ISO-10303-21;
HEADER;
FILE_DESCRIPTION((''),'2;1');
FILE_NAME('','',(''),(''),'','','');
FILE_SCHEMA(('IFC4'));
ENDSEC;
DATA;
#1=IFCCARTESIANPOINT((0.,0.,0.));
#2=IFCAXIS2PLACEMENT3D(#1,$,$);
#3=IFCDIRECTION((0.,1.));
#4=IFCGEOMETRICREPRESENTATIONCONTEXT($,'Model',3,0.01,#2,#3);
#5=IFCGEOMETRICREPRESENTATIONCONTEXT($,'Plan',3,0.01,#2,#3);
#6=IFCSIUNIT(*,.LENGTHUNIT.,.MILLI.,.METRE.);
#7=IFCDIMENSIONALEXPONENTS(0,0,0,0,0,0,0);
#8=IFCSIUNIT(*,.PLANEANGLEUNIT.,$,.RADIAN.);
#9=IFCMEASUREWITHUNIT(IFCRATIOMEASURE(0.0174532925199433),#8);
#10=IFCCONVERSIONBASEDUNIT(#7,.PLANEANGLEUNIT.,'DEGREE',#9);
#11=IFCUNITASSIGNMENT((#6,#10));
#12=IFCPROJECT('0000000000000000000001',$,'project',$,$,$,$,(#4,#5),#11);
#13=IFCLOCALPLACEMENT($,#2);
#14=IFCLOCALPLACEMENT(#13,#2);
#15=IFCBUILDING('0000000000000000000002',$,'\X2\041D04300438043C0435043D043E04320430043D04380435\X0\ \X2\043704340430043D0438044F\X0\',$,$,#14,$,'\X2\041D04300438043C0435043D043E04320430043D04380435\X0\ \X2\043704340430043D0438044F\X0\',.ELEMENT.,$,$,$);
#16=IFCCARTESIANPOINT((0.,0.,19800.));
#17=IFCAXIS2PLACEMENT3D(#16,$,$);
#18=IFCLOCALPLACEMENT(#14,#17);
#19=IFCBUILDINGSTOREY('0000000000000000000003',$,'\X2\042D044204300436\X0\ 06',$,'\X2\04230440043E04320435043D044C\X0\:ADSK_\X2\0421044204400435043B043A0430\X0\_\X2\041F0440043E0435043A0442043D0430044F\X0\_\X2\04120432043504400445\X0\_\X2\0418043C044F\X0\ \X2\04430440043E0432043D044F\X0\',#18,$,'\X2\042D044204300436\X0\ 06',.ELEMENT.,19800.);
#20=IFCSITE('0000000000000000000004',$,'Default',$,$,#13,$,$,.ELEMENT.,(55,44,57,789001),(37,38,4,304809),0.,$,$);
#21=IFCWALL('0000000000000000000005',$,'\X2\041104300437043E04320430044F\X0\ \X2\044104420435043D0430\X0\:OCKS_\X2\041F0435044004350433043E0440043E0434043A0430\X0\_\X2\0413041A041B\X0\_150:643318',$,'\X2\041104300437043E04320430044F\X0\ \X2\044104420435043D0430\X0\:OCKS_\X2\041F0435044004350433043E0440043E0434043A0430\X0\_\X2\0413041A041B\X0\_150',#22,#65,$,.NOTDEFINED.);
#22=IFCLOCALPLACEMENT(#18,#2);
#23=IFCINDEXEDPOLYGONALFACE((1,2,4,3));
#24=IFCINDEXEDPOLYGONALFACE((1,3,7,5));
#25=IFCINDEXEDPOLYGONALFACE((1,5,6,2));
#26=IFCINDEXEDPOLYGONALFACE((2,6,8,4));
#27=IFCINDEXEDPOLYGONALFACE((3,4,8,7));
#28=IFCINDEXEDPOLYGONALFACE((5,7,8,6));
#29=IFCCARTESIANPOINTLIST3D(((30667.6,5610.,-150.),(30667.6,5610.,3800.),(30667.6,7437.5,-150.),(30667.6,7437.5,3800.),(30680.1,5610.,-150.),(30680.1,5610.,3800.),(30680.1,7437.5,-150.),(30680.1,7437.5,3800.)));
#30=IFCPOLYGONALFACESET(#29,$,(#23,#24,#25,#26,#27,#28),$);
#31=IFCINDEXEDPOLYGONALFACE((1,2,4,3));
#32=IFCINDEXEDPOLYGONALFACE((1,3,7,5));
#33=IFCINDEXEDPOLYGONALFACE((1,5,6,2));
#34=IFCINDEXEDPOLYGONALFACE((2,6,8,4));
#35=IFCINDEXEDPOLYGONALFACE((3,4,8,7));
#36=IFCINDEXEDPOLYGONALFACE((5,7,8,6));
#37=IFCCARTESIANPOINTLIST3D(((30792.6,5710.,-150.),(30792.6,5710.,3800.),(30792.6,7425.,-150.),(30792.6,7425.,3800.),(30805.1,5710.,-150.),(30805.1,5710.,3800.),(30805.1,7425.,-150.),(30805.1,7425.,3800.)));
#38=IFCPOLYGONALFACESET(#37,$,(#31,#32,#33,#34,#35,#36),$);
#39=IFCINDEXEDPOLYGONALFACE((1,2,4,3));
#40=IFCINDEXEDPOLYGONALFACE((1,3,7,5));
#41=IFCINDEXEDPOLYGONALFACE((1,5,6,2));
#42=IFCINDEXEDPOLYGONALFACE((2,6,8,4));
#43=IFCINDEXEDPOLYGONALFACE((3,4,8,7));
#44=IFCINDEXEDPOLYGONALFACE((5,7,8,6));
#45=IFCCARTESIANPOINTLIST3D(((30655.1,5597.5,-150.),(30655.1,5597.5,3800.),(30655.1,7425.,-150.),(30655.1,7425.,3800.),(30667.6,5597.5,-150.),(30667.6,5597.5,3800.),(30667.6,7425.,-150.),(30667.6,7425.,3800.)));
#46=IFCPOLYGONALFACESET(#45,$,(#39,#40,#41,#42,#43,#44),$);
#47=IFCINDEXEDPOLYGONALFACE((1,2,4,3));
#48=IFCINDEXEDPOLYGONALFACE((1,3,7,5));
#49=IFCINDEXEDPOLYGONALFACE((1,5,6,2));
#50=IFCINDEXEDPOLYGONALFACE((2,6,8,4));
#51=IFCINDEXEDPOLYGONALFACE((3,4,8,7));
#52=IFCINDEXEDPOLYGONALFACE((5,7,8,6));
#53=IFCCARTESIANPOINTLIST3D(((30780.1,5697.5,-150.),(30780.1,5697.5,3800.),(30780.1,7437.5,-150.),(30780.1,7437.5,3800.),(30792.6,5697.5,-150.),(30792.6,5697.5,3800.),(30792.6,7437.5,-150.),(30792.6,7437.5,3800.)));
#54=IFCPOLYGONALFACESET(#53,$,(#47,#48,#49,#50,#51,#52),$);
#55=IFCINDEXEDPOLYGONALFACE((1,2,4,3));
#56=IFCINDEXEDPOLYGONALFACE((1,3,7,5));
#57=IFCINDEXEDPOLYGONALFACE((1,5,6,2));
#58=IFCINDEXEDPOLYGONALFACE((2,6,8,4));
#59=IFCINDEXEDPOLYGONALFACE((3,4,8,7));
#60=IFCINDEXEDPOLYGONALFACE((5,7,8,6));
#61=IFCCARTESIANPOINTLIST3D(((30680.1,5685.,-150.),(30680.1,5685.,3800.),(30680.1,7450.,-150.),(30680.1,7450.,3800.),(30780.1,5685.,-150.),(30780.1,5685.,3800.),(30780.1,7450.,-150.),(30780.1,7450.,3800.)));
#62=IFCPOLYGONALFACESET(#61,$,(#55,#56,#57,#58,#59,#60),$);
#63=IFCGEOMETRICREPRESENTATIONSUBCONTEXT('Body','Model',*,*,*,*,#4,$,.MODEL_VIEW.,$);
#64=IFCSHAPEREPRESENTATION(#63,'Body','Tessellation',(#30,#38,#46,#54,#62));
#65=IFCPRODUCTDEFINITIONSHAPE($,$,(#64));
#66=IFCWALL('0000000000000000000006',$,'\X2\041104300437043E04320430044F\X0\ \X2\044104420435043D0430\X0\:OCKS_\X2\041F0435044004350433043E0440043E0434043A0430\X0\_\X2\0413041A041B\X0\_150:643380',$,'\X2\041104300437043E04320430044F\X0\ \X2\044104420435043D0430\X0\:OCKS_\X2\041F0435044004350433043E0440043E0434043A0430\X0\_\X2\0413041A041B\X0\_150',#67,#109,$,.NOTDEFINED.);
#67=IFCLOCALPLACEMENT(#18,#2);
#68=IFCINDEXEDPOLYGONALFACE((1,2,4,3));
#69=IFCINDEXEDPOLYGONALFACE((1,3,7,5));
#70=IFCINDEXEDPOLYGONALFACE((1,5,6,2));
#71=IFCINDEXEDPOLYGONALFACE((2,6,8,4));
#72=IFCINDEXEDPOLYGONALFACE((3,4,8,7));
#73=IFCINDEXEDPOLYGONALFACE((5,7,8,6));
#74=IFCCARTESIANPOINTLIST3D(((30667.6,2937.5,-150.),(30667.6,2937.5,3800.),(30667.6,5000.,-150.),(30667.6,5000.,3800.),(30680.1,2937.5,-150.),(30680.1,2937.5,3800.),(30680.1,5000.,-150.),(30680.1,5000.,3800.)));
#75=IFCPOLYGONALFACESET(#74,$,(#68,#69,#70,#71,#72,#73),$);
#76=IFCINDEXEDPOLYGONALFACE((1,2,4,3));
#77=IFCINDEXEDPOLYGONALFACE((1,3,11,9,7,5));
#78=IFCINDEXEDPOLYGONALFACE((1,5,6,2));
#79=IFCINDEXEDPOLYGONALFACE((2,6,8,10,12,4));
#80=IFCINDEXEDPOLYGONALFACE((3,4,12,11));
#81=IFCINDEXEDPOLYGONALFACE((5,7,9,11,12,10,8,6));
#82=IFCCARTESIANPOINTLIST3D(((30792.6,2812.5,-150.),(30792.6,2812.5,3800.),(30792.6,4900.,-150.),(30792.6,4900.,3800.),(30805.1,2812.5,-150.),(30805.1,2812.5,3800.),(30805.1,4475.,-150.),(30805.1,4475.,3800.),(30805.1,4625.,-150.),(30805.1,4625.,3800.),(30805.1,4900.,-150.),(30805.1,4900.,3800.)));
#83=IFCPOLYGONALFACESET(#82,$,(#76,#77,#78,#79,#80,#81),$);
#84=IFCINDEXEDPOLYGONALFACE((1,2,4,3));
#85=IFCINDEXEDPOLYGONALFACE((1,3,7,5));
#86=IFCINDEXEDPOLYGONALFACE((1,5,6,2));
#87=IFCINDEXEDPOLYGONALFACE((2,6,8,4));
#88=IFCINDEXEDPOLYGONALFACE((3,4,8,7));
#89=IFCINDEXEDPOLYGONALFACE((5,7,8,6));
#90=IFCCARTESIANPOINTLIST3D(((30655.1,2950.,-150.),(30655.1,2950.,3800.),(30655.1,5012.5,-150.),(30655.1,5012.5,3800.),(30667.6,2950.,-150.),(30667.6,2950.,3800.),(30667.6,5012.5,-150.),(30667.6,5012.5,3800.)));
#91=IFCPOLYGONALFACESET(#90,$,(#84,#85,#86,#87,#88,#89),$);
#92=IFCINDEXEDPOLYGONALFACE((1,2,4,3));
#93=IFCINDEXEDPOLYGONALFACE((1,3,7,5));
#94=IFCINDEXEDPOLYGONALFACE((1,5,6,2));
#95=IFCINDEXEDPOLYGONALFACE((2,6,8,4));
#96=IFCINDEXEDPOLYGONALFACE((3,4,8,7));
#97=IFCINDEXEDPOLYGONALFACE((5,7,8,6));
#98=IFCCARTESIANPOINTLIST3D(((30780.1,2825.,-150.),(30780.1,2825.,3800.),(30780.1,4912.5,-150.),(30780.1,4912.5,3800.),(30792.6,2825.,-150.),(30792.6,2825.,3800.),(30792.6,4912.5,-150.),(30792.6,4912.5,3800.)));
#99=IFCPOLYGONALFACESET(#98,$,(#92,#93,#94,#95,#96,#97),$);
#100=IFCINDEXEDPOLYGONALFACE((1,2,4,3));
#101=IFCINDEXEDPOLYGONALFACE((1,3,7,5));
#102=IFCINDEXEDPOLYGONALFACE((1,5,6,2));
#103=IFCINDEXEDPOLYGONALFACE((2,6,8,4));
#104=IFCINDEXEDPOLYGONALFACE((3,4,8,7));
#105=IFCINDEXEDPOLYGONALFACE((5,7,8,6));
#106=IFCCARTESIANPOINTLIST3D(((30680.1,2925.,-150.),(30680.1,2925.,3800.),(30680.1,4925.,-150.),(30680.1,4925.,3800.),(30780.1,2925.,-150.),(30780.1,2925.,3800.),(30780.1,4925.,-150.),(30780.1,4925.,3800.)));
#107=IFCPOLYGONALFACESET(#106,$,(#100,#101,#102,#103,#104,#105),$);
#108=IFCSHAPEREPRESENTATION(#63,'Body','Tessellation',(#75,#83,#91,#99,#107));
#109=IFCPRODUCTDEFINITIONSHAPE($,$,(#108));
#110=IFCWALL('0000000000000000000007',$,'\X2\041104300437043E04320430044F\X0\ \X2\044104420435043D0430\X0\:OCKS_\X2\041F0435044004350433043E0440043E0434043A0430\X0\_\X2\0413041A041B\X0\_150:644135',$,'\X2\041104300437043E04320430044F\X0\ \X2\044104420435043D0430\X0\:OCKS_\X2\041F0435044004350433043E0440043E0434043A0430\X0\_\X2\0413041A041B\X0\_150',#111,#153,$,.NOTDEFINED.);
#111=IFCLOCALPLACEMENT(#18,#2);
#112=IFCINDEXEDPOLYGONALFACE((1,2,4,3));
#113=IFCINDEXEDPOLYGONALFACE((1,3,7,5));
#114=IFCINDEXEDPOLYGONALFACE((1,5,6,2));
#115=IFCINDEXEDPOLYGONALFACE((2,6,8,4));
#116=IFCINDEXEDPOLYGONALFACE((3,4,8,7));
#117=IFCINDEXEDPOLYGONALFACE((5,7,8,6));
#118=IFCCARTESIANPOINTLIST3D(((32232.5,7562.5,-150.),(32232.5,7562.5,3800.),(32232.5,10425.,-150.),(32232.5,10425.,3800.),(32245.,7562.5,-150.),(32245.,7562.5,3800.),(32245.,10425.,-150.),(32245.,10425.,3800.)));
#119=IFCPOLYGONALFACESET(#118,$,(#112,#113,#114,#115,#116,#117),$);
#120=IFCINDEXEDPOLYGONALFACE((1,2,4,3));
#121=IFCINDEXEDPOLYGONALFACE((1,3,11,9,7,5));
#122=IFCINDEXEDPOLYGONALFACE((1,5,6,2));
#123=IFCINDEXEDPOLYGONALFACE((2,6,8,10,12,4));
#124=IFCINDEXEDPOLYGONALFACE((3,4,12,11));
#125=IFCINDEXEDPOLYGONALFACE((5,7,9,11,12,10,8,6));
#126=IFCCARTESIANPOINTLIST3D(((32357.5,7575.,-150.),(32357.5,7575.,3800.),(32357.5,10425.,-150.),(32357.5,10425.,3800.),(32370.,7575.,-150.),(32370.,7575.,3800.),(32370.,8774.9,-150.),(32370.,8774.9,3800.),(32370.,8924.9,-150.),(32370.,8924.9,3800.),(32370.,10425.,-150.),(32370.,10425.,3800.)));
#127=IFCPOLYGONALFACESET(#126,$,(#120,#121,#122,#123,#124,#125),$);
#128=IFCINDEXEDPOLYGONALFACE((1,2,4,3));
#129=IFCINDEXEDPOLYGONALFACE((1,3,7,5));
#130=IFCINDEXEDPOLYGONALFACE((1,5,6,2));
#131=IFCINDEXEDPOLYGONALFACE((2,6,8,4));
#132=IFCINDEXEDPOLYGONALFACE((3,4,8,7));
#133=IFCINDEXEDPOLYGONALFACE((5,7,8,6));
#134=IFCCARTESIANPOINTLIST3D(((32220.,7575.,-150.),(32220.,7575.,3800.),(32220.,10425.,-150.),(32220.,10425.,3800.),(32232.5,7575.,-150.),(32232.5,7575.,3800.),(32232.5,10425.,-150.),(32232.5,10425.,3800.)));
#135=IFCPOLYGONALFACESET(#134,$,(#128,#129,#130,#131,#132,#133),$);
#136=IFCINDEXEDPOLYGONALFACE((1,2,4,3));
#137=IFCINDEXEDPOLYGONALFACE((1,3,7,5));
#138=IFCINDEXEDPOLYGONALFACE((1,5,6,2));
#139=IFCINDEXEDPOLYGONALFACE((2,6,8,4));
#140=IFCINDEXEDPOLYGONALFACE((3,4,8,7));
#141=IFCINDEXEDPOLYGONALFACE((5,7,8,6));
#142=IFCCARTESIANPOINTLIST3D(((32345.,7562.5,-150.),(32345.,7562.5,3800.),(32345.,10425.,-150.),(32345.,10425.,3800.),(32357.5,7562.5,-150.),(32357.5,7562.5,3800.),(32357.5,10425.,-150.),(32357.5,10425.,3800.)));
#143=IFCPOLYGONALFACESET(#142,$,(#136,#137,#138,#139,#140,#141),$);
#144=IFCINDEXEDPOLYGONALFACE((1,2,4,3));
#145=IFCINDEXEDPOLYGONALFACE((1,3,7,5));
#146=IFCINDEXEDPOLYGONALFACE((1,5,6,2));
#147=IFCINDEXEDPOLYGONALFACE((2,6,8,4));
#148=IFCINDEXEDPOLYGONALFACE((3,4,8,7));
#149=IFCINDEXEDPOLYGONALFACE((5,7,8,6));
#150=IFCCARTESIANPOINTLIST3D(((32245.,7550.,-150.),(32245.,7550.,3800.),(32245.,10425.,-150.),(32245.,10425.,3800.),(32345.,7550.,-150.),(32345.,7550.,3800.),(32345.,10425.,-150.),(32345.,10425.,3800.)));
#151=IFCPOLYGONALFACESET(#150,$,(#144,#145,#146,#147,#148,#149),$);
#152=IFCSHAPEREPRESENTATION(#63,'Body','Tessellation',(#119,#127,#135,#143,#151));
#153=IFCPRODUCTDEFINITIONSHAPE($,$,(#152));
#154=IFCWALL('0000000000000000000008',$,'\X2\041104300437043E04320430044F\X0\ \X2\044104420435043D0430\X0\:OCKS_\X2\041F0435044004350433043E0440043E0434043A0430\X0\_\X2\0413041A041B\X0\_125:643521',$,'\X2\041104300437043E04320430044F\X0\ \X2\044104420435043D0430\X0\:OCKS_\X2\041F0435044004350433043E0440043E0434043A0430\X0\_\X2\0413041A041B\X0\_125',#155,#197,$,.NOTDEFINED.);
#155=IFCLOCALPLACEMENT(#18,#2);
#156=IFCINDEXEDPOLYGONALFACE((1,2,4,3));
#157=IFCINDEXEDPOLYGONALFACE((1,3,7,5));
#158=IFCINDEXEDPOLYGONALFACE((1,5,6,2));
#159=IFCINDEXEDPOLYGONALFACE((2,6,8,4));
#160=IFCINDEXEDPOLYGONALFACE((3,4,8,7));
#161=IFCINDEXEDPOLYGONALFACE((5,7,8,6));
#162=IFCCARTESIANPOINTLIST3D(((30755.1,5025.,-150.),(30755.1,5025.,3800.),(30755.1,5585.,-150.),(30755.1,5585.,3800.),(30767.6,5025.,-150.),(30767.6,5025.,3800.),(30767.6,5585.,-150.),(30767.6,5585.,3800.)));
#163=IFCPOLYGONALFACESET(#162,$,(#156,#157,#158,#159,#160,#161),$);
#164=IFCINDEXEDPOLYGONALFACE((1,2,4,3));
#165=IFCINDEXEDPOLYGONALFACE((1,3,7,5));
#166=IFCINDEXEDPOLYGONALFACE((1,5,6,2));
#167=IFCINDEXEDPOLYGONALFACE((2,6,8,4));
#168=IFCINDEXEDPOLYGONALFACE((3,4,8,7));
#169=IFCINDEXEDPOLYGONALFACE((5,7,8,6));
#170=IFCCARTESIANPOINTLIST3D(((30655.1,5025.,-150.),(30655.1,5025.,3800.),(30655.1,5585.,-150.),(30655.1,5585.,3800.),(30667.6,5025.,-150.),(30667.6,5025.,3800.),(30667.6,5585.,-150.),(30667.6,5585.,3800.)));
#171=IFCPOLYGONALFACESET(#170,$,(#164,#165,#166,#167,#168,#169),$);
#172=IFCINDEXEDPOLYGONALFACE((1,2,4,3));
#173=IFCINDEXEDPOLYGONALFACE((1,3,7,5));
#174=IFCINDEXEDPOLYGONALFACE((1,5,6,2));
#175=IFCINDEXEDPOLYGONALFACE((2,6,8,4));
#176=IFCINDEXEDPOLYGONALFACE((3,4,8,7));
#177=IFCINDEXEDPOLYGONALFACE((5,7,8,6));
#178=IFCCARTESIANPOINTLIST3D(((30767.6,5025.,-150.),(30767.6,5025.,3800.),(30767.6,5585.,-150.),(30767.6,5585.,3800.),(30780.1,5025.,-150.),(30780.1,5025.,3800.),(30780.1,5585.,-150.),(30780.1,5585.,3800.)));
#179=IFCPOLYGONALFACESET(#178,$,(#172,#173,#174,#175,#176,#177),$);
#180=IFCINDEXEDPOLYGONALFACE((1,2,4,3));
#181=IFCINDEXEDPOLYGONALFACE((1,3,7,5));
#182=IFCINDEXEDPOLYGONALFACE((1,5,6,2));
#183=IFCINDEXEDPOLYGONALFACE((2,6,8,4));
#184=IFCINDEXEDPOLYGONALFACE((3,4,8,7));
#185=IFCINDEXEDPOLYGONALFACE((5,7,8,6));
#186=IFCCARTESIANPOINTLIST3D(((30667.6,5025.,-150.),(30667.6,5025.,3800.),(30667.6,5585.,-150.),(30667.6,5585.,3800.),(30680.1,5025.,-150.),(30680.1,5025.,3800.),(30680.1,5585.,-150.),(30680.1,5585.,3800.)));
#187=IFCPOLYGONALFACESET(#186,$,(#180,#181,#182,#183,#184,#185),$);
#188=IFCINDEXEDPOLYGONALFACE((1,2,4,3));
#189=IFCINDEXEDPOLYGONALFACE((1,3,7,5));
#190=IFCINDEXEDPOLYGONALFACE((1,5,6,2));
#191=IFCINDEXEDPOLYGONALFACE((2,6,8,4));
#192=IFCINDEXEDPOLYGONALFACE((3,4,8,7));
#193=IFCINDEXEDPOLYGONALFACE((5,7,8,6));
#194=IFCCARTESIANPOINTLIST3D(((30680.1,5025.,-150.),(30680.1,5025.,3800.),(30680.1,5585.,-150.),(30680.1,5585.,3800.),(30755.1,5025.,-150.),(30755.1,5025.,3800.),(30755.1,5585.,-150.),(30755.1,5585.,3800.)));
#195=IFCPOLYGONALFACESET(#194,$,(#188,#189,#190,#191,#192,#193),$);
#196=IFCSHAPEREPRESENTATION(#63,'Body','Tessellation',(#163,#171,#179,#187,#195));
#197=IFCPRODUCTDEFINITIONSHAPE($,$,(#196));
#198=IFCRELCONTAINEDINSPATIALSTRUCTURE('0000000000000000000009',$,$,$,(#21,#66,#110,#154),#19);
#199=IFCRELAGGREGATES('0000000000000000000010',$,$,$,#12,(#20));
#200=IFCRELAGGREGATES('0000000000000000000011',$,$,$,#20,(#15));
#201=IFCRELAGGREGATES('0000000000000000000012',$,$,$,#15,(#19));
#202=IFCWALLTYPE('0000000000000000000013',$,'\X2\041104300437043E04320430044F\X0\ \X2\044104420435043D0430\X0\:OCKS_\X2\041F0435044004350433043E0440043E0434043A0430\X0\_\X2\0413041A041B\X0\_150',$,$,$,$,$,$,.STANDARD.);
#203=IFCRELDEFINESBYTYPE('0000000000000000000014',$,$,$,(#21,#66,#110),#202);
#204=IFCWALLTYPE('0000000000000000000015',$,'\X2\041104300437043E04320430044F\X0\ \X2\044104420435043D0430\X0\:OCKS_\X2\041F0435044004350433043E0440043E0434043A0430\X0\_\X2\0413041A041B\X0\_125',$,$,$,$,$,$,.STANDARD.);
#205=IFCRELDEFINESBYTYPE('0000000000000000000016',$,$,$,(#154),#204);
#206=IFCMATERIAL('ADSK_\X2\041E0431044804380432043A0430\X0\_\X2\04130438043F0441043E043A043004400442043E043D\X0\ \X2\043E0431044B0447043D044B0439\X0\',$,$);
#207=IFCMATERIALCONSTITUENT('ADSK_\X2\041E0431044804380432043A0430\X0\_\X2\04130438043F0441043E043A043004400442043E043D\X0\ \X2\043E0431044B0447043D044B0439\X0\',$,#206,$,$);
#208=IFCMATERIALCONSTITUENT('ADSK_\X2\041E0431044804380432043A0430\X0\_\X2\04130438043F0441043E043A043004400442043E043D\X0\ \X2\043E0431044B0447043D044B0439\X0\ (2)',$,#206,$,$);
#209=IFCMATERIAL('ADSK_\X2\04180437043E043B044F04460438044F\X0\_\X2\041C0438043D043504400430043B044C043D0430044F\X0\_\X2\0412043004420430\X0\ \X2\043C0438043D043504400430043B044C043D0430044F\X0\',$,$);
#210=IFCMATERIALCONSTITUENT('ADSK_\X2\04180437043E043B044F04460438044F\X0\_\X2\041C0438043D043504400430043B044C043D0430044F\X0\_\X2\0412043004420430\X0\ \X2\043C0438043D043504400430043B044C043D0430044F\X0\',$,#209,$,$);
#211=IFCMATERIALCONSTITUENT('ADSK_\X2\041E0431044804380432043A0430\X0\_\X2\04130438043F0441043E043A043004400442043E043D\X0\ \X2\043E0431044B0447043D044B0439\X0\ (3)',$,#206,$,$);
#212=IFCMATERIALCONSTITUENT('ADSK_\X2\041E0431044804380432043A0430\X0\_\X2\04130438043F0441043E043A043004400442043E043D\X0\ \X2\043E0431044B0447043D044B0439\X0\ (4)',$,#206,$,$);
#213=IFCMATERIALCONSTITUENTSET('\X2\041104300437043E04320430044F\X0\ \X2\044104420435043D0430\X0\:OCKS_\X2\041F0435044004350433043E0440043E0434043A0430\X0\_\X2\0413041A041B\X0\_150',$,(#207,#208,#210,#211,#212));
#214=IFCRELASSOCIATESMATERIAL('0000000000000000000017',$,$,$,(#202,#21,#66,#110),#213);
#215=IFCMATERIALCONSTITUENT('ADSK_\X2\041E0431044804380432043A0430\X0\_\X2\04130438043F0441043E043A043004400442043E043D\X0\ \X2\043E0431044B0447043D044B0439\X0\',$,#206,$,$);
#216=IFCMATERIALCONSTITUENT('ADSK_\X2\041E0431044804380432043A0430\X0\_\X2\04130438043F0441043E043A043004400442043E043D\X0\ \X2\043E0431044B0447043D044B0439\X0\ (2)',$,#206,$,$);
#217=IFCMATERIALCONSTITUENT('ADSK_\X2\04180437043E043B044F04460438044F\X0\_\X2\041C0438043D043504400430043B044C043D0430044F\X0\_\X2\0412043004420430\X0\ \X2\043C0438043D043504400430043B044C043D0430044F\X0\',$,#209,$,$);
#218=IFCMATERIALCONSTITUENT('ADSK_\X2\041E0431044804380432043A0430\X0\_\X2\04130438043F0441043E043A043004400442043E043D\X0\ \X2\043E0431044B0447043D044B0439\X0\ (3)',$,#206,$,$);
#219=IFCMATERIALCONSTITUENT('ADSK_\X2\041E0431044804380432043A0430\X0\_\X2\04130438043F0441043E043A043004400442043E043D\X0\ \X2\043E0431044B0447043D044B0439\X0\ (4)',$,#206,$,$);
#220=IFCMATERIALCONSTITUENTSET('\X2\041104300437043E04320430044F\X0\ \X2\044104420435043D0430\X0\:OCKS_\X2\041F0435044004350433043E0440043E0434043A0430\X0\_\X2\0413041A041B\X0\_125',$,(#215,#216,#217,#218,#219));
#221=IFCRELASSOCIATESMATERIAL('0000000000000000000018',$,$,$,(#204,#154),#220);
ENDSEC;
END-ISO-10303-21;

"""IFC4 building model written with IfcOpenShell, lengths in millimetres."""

from ifc_helpers import new_model, entity, si_unit, converted_unit, direction, frame, origin, place, context, subcontext, project, spatial, indexed_curve, outline, extrude, material, constituent, constituent_set, type_object, element, save


model = new_model("IFC4")

# Units and contexts
model_context = context("Model", 3, precision=0.01, world=origin(), true_north=direction((0.0, 1.0)))
plan_context = context("Plan", 3, precision=0.01, world=origin(), true_north=direction((0.0, 1.0)))
body_context = subcontext(model_context, "Body", "Model", "MODEL_VIEW")
ifc_project = project(units=[si_unit("LENGTHUNIT", "METRE", prefix="MILLI"), converted_unit("PLANEANGLEUNIT", "DEGREE", entity("IfcRatioMeasure", 0.0174532925199433), si_unit("PLANEANGLEUNIT", "RADIAN"), dimensions=[0, 0, 0, 0, 0, 0, 0])], contexts=[model_context, plan_context])

# Site, building, storey
site_placement = place(None, frame((0.0, 0.0, 0.0)))
site = spatial("IfcSite", under=ifc_project, at=site_placement, Name="Default", CompositionType="ELEMENT", RefLatitude=(55, 44, 57, 789001), RefLongitude=(37, 38, 4, 304809), RefElevation=0.0)
building_placement = place(site_placement, origin())
building = spatial("IfcBuilding", under=site, at=building_placement, Name="Наименование здания", LongName="Наименование здания", CompositionType="ELEMENT")
storey_placement = place(building_placement, frame((0.0, 0.0, 19800.0)))
storey = spatial("IfcBuildingStorey", under=building, at=storey_placement, Name="Этаж 06", ObjectType="Уровень:ADSK_Стрелка_Проектная_Вверх_Имя уровня", LongName="Этаж 06", CompositionType="ELEMENT", Elevation=19800.0)

# Shared definitions
ifc_material_1 = material(Name="ADSK_Обшивка_Гипсокартон обычный")
ifc_constituent_1 = constituent(ifc_material_1, Name="ADSK_Обшивка_Гипсокартон обычный")
ifc_constituent_2 = constituent(ifc_material_1, Name="ADSK_Обшивка_Гипсокартон обычный (2)")
ifc_material_2 = material(Name="ADSK_Изоляция_Минеральная_Вата минеральная")
ifc_constituent_3 = constituent(ifc_material_2, Name="ADSK_Изоляция_Минеральная_Вата минеральная")
ifc_constituent_4 = constituent(ifc_material_1, Name="ADSK_Обшивка_Гипсокартон обычный (3)")
ifc_constituent_5 = constituent(ifc_material_1, Name="ADSK_Обшивка_Гипсокартон обычный (4)")
ifc_constituent_set_1 = constituent_set(constituents=[ifc_constituent_1, ifc_constituent_2, ifc_constituent_3, ifc_constituent_4, ifc_constituent_5], Name="Базовая стена:OCKS_Перегородка_ГКЛ_150")
wall_type_1 = type_object("IfcWallType", Name="Базовая стена:OCKS_Перегородка_ГКЛ_150", PredefinedType="STANDARD", material=ifc_constituent_set_1)

# Walls
wall_1_placement = place(storey_placement, frame((30730.1, 7425.0, -150.0), z_axis=(0.0, 0.0, 1.0), x_axis=(0.0, -1.0, 0.0)))
element("IfcWall", 1, at=wall_1_placement, inside=storey, type_object=wall_type_1, material=ifc_constituent_set_1, Name="Базовая стена:OCKS_Перегородка_ГКЛ_150:643318", ObjectType="Базовая стена:OCKS_Перегородка_ГКЛ_150", PredefinedType="NOTDEFINED", context=body_context, shape_type="SweptSolid", body=[
    extrude(outline(indexed_curve([(-913.8, -6.2), (913.8, -6.2), (913.8, 6.3), (-913.8, 6.3), (-913.8, -6.2)], self_intersect=False)), frame((901.3, -56.3, 0.0)), (0.0, 0.0, 1.0), 3950.0),
    extrude(outline(indexed_curve([(-6.3, -857.5), (6.2, -857.5), (6.3, 857.5), (-6.2, 857.5), (-6.3, -857.5)], self_intersect=False)), frame((857.5, 68.7, 0.0), z_axis=(0.0, 0.0, 1.0), x_axis=(0.0, -1.0, 0.0)), (0.0, 0.0, 1.0), 3950.0),
    extrude(outline(indexed_curve([(-6.3, -913.8), (6.2, -913.8), (6.3, 913.8), (-6.2, 913.8), (-6.3, -913.8)], self_intersect=False)), frame((913.8, -68.8, 0.0), z_axis=(0.0, 0.0, 1.0), x_axis=(0.0, 1.0, 0.0)), (0.0, 0.0, 1.0), 3950.0),
    extrude(outline(indexed_curve([(-870.0, -6.2), (870.0, -6.2), (870.0, 6.3), (-870.0, 6.3), (-870.0, -6.2)], self_intersect=False)), frame((857.5, 56.2, 0.0)), (0.0, 0.0, 1.0), 3950.0),
    extrude(outline(indexed_curve([(-882.5, -50.0), (882.5, -50.0), (882.5, 50.0), (-882.5, 50.0), (-882.5, -50.0)], self_intersect=False)), frame((857.5, 0.0, 0.0)), (0.0, 0.0, 1.0), 3950.0),
])
wall_2_placement = place(storey_placement, frame((30730.1, 4900.0, -150.0), z_axis=(0.0, 0.0, 1.0), x_axis=(0.0, -1.0, 0.0)))
element("IfcWall", 2, at=wall_2_placement, inside=storey, type_object=wall_type_1, material=ifc_constituent_set_1, Name="Базовая стена:OCKS_Перегородка_ГКЛ_150:643380", ObjectType="Базовая стена:OCKS_Перегородка_ГКЛ_150", PredefinedType="NOTDEFINED", context=body_context, shape_type="SweptSolid", body=[
    extrude(outline(indexed_curve([(-1031.3, -6.3), (1031.3, -6.3), (1031.3, 6.2), (-1031.3, 6.2), (-1031.3, -6.3)], self_intersect=False)), frame((931.3, -56.2, 0.0)), (0.0, 0.0, 1.0), 3950.0),
    extrude(outline(indexed_curve([(387.5, -4.2), (537.5, -4.2), (812.5, -4.2), (812.5, 8.3), (-1275.0, 8.3), (-1275.0, -4.2), (387.5, -4.2)], self_intersect=False)), frame((812.5, 70.8, 0.0), z_axis=(0.0, 0.0, 1.0), x_axis=(-1.0, 0.0, 0.0)), (0.0, 0.0, 1.0), 3950.0),
    extrude(outline(indexed_curve([(-6.3, -1031.3), (6.2, -1031.3), (6.3, 1031.3), (-6.2, 1031.3), (-6.3, -1031.3)], self_intersect=False)), frame((918.8, -68.8, 0.0), z_axis=(0.0, 0.0, 1.0), x_axis=(0.0, 1.0, 0.0)), (0.0, 0.0, 1.0), 3950.0),
    extrude(outline(indexed_curve([(-1043.8, -6.3), (1043.8, -6.3), (1043.8, 6.2), (-1043.8, 6.2), (-1043.8, -6.3)], self_intersect=False)), frame((1031.3, 56.3, 0.0)), (0.0, 0.0, 1.0), 3950.0),
    extrude(outline(indexed_curve([(-1000.0, -50.0), (1000.0, -50.0), (1000.0, 50.0), (-1000.0, 50.0), (-1000.0, -50.0)], self_intersect=False)), frame((975.0, 0.0, 0.0)), (0.0, 0.0, 1.0), 3950.0),
])

# Walls
wall_3_placement = place(storey_placement, frame((32295.0, 10425.0, -150.0), z_axis=(0.0, 0.0, 1.0), x_axis=(0.0, -1.0, 0.0)))
element("IfcWall", 3, at=wall_3_placement, inside=storey, type_object=wall_type_1, material=ifc_constituent_set_1, Name="Базовая стена:OCKS_Перегородка_ГКЛ_150:644135", ObjectType="Базовая стена:OCKS_Перегородка_ГКЛ_150", PredefinedType="NOTDEFINED", context=body_context, shape_type="SweptSolid", body=[
    extrude(outline(indexed_curve([(-1431.2, -6.2), (1431.2, -6.2), (1431.2, 6.3), (-1431.2, 6.3), (-1431.2, -6.2)], self_intersect=False)), frame((1431.2, -56.3, 0.0)), (0.0, 0.0, 1.0), 3950.0),
    extrude(outline(indexed_curve([(-175.0, -4.2), (-25.0, -4.2), (1475.0, -4.2), (1475.0, 8.3), (-1375.0, 8.3), (-1375.0, -4.2), (-175.0, -4.2)], self_intersect=False)), frame((1475.0, 70.8, 0.0), z_axis=(0.0, 0.0, 1.0), x_axis=(-1.0, 0.0, 0.0)), (0.0, 0.0, 1.0), 3950.0),
    extrude(outline(indexed_curve([(-6.3, -1425.0), (6.2, -1425.0), (6.3, 1425.0), (-6.2, 1425.0), (-6.3, -1425.0)], self_intersect=False)), frame((1425.0, -68.7, 0.0), z_axis=(0.0, 0.0, 1.0), x_axis=(0.0, 1.0, 0.0)), (0.0, 0.0, 1.0), 3950.0),
    extrude(outline(indexed_curve([(-1431.2, -6.2), (1431.2, -6.2), (1431.2, 6.3), (-1431.2, 6.3), (-1431.2, -6.2)], self_intersect=False)), frame((1431.2, 56.2, 0.0)), (0.0, 0.0, 1.0), 3950.0),
    extrude(outline(indexed_curve([(-1437.5, -50.0), (1437.5, -50.0), (1437.5, 50.0), (-1437.5, 50.0), (-1437.5, -50.0)], self_intersect=False)), frame((1437.5, 0.0, 0.0)), (0.0, 0.0, 1.0), 3950.0),
])
ifc_constituent_6 = constituent(ifc_material_1, Name="ADSK_Обшивка_Гипсокартон обычный")
ifc_constituent_7 = constituent(ifc_material_1, Name="ADSK_Обшивка_Гипсокартон обычный (2)")
ifc_constituent_8 = constituent(ifc_material_2, Name="ADSK_Изоляция_Минеральная_Вата минеральная")
ifc_constituent_9 = constituent(ifc_material_1, Name="ADSK_Обшивка_Гипсокартон обычный (3)")
ifc_constituent_10 = constituent(ifc_material_1, Name="ADSK_Обшивка_Гипсокартон обычный (4)")
ifc_constituent_set_2 = constituent_set(constituents=[ifc_constituent_6, ifc_constituent_7, ifc_constituent_8, ifc_constituent_9, ifc_constituent_10], Name="Базовая стена:OCKS_Перегородка_ГКЛ_125")
wall_type_2 = type_object("IfcWallType", Name="Базовая стена:OCKS_Перегородка_ГКЛ_125", PredefinedType="STANDARD", material=ifc_constituent_set_2)
wall_4_placement = place(storey_placement, frame((30717.6, 5585.0, -150.0), z_axis=(0.0, 0.0, 1.0), x_axis=(0.0, -1.0, 0.0)))
element("IfcWall", 4, at=wall_4_placement, inside=storey, type_object=wall_type_2, material=ifc_constituent_set_2, Name="Базовая стена:OCKS_Перегородка_ГКЛ_125:643521", ObjectType="Базовая стена:OCKS_Перегородка_ГКЛ_125", PredefinedType="NOTDEFINED", context=body_context, shape_type="SweptSolid", body=[
    extrude(outline(indexed_curve([(-280.0, -6.3), (280.0, -6.3), (280.0, 6.2), (-280.0, 6.2), (-280.0, -6.3)], self_intersect=False)), frame((280.0, 43.8, 0.0)), (0.0, 0.0, 1.0), 3950.0),
    extrude(outline(indexed_curve([(-6.3, -280.0), (6.2, -280.0), (6.2, 280.0), (-6.3, 280.0), (-6.3, -280.0)], self_intersect=False)), frame((280.0, -56.3, 0.0), z_axis=(0.0, 0.0, 1.0), x_axis=(0.0, 1.0, 0.0)), (0.0, 0.0, 1.0), 3950.0),
    extrude(outline(indexed_curve([(-6.2, -280.0), (6.2, -280.0), (6.2, 280.0), (-6.2, 280.0), (-6.2, -280.0)], self_intersect=False)), frame((280.0, 56.3, 0.0), z_axis=(0.0, 0.0, 1.0), x_axis=(0.0, -1.0, 0.0)), (0.0, 0.0, 1.0), 3950.0),
    extrude(outline(indexed_curve([(-280.0, -6.3), (280.0, -6.3), (280.0, 6.2), (-280.0, 6.2), (-280.0, -6.3)], self_intersect=False)), frame((280.0, -43.7, 0.0)), (0.0, 0.0, 1.0), 3950.0),
    extrude(outline(indexed_curve([(-280.0, -37.5), (280.0, -37.5), (280.0, 37.5), (-280.0, 37.5), (-280.0, -37.5)], self_intersect=False)), frame((280.0, 0.0, 0.0)), (0.0, 0.0, 1.0), 3950.0),
])

save(model, "model.ifc")
